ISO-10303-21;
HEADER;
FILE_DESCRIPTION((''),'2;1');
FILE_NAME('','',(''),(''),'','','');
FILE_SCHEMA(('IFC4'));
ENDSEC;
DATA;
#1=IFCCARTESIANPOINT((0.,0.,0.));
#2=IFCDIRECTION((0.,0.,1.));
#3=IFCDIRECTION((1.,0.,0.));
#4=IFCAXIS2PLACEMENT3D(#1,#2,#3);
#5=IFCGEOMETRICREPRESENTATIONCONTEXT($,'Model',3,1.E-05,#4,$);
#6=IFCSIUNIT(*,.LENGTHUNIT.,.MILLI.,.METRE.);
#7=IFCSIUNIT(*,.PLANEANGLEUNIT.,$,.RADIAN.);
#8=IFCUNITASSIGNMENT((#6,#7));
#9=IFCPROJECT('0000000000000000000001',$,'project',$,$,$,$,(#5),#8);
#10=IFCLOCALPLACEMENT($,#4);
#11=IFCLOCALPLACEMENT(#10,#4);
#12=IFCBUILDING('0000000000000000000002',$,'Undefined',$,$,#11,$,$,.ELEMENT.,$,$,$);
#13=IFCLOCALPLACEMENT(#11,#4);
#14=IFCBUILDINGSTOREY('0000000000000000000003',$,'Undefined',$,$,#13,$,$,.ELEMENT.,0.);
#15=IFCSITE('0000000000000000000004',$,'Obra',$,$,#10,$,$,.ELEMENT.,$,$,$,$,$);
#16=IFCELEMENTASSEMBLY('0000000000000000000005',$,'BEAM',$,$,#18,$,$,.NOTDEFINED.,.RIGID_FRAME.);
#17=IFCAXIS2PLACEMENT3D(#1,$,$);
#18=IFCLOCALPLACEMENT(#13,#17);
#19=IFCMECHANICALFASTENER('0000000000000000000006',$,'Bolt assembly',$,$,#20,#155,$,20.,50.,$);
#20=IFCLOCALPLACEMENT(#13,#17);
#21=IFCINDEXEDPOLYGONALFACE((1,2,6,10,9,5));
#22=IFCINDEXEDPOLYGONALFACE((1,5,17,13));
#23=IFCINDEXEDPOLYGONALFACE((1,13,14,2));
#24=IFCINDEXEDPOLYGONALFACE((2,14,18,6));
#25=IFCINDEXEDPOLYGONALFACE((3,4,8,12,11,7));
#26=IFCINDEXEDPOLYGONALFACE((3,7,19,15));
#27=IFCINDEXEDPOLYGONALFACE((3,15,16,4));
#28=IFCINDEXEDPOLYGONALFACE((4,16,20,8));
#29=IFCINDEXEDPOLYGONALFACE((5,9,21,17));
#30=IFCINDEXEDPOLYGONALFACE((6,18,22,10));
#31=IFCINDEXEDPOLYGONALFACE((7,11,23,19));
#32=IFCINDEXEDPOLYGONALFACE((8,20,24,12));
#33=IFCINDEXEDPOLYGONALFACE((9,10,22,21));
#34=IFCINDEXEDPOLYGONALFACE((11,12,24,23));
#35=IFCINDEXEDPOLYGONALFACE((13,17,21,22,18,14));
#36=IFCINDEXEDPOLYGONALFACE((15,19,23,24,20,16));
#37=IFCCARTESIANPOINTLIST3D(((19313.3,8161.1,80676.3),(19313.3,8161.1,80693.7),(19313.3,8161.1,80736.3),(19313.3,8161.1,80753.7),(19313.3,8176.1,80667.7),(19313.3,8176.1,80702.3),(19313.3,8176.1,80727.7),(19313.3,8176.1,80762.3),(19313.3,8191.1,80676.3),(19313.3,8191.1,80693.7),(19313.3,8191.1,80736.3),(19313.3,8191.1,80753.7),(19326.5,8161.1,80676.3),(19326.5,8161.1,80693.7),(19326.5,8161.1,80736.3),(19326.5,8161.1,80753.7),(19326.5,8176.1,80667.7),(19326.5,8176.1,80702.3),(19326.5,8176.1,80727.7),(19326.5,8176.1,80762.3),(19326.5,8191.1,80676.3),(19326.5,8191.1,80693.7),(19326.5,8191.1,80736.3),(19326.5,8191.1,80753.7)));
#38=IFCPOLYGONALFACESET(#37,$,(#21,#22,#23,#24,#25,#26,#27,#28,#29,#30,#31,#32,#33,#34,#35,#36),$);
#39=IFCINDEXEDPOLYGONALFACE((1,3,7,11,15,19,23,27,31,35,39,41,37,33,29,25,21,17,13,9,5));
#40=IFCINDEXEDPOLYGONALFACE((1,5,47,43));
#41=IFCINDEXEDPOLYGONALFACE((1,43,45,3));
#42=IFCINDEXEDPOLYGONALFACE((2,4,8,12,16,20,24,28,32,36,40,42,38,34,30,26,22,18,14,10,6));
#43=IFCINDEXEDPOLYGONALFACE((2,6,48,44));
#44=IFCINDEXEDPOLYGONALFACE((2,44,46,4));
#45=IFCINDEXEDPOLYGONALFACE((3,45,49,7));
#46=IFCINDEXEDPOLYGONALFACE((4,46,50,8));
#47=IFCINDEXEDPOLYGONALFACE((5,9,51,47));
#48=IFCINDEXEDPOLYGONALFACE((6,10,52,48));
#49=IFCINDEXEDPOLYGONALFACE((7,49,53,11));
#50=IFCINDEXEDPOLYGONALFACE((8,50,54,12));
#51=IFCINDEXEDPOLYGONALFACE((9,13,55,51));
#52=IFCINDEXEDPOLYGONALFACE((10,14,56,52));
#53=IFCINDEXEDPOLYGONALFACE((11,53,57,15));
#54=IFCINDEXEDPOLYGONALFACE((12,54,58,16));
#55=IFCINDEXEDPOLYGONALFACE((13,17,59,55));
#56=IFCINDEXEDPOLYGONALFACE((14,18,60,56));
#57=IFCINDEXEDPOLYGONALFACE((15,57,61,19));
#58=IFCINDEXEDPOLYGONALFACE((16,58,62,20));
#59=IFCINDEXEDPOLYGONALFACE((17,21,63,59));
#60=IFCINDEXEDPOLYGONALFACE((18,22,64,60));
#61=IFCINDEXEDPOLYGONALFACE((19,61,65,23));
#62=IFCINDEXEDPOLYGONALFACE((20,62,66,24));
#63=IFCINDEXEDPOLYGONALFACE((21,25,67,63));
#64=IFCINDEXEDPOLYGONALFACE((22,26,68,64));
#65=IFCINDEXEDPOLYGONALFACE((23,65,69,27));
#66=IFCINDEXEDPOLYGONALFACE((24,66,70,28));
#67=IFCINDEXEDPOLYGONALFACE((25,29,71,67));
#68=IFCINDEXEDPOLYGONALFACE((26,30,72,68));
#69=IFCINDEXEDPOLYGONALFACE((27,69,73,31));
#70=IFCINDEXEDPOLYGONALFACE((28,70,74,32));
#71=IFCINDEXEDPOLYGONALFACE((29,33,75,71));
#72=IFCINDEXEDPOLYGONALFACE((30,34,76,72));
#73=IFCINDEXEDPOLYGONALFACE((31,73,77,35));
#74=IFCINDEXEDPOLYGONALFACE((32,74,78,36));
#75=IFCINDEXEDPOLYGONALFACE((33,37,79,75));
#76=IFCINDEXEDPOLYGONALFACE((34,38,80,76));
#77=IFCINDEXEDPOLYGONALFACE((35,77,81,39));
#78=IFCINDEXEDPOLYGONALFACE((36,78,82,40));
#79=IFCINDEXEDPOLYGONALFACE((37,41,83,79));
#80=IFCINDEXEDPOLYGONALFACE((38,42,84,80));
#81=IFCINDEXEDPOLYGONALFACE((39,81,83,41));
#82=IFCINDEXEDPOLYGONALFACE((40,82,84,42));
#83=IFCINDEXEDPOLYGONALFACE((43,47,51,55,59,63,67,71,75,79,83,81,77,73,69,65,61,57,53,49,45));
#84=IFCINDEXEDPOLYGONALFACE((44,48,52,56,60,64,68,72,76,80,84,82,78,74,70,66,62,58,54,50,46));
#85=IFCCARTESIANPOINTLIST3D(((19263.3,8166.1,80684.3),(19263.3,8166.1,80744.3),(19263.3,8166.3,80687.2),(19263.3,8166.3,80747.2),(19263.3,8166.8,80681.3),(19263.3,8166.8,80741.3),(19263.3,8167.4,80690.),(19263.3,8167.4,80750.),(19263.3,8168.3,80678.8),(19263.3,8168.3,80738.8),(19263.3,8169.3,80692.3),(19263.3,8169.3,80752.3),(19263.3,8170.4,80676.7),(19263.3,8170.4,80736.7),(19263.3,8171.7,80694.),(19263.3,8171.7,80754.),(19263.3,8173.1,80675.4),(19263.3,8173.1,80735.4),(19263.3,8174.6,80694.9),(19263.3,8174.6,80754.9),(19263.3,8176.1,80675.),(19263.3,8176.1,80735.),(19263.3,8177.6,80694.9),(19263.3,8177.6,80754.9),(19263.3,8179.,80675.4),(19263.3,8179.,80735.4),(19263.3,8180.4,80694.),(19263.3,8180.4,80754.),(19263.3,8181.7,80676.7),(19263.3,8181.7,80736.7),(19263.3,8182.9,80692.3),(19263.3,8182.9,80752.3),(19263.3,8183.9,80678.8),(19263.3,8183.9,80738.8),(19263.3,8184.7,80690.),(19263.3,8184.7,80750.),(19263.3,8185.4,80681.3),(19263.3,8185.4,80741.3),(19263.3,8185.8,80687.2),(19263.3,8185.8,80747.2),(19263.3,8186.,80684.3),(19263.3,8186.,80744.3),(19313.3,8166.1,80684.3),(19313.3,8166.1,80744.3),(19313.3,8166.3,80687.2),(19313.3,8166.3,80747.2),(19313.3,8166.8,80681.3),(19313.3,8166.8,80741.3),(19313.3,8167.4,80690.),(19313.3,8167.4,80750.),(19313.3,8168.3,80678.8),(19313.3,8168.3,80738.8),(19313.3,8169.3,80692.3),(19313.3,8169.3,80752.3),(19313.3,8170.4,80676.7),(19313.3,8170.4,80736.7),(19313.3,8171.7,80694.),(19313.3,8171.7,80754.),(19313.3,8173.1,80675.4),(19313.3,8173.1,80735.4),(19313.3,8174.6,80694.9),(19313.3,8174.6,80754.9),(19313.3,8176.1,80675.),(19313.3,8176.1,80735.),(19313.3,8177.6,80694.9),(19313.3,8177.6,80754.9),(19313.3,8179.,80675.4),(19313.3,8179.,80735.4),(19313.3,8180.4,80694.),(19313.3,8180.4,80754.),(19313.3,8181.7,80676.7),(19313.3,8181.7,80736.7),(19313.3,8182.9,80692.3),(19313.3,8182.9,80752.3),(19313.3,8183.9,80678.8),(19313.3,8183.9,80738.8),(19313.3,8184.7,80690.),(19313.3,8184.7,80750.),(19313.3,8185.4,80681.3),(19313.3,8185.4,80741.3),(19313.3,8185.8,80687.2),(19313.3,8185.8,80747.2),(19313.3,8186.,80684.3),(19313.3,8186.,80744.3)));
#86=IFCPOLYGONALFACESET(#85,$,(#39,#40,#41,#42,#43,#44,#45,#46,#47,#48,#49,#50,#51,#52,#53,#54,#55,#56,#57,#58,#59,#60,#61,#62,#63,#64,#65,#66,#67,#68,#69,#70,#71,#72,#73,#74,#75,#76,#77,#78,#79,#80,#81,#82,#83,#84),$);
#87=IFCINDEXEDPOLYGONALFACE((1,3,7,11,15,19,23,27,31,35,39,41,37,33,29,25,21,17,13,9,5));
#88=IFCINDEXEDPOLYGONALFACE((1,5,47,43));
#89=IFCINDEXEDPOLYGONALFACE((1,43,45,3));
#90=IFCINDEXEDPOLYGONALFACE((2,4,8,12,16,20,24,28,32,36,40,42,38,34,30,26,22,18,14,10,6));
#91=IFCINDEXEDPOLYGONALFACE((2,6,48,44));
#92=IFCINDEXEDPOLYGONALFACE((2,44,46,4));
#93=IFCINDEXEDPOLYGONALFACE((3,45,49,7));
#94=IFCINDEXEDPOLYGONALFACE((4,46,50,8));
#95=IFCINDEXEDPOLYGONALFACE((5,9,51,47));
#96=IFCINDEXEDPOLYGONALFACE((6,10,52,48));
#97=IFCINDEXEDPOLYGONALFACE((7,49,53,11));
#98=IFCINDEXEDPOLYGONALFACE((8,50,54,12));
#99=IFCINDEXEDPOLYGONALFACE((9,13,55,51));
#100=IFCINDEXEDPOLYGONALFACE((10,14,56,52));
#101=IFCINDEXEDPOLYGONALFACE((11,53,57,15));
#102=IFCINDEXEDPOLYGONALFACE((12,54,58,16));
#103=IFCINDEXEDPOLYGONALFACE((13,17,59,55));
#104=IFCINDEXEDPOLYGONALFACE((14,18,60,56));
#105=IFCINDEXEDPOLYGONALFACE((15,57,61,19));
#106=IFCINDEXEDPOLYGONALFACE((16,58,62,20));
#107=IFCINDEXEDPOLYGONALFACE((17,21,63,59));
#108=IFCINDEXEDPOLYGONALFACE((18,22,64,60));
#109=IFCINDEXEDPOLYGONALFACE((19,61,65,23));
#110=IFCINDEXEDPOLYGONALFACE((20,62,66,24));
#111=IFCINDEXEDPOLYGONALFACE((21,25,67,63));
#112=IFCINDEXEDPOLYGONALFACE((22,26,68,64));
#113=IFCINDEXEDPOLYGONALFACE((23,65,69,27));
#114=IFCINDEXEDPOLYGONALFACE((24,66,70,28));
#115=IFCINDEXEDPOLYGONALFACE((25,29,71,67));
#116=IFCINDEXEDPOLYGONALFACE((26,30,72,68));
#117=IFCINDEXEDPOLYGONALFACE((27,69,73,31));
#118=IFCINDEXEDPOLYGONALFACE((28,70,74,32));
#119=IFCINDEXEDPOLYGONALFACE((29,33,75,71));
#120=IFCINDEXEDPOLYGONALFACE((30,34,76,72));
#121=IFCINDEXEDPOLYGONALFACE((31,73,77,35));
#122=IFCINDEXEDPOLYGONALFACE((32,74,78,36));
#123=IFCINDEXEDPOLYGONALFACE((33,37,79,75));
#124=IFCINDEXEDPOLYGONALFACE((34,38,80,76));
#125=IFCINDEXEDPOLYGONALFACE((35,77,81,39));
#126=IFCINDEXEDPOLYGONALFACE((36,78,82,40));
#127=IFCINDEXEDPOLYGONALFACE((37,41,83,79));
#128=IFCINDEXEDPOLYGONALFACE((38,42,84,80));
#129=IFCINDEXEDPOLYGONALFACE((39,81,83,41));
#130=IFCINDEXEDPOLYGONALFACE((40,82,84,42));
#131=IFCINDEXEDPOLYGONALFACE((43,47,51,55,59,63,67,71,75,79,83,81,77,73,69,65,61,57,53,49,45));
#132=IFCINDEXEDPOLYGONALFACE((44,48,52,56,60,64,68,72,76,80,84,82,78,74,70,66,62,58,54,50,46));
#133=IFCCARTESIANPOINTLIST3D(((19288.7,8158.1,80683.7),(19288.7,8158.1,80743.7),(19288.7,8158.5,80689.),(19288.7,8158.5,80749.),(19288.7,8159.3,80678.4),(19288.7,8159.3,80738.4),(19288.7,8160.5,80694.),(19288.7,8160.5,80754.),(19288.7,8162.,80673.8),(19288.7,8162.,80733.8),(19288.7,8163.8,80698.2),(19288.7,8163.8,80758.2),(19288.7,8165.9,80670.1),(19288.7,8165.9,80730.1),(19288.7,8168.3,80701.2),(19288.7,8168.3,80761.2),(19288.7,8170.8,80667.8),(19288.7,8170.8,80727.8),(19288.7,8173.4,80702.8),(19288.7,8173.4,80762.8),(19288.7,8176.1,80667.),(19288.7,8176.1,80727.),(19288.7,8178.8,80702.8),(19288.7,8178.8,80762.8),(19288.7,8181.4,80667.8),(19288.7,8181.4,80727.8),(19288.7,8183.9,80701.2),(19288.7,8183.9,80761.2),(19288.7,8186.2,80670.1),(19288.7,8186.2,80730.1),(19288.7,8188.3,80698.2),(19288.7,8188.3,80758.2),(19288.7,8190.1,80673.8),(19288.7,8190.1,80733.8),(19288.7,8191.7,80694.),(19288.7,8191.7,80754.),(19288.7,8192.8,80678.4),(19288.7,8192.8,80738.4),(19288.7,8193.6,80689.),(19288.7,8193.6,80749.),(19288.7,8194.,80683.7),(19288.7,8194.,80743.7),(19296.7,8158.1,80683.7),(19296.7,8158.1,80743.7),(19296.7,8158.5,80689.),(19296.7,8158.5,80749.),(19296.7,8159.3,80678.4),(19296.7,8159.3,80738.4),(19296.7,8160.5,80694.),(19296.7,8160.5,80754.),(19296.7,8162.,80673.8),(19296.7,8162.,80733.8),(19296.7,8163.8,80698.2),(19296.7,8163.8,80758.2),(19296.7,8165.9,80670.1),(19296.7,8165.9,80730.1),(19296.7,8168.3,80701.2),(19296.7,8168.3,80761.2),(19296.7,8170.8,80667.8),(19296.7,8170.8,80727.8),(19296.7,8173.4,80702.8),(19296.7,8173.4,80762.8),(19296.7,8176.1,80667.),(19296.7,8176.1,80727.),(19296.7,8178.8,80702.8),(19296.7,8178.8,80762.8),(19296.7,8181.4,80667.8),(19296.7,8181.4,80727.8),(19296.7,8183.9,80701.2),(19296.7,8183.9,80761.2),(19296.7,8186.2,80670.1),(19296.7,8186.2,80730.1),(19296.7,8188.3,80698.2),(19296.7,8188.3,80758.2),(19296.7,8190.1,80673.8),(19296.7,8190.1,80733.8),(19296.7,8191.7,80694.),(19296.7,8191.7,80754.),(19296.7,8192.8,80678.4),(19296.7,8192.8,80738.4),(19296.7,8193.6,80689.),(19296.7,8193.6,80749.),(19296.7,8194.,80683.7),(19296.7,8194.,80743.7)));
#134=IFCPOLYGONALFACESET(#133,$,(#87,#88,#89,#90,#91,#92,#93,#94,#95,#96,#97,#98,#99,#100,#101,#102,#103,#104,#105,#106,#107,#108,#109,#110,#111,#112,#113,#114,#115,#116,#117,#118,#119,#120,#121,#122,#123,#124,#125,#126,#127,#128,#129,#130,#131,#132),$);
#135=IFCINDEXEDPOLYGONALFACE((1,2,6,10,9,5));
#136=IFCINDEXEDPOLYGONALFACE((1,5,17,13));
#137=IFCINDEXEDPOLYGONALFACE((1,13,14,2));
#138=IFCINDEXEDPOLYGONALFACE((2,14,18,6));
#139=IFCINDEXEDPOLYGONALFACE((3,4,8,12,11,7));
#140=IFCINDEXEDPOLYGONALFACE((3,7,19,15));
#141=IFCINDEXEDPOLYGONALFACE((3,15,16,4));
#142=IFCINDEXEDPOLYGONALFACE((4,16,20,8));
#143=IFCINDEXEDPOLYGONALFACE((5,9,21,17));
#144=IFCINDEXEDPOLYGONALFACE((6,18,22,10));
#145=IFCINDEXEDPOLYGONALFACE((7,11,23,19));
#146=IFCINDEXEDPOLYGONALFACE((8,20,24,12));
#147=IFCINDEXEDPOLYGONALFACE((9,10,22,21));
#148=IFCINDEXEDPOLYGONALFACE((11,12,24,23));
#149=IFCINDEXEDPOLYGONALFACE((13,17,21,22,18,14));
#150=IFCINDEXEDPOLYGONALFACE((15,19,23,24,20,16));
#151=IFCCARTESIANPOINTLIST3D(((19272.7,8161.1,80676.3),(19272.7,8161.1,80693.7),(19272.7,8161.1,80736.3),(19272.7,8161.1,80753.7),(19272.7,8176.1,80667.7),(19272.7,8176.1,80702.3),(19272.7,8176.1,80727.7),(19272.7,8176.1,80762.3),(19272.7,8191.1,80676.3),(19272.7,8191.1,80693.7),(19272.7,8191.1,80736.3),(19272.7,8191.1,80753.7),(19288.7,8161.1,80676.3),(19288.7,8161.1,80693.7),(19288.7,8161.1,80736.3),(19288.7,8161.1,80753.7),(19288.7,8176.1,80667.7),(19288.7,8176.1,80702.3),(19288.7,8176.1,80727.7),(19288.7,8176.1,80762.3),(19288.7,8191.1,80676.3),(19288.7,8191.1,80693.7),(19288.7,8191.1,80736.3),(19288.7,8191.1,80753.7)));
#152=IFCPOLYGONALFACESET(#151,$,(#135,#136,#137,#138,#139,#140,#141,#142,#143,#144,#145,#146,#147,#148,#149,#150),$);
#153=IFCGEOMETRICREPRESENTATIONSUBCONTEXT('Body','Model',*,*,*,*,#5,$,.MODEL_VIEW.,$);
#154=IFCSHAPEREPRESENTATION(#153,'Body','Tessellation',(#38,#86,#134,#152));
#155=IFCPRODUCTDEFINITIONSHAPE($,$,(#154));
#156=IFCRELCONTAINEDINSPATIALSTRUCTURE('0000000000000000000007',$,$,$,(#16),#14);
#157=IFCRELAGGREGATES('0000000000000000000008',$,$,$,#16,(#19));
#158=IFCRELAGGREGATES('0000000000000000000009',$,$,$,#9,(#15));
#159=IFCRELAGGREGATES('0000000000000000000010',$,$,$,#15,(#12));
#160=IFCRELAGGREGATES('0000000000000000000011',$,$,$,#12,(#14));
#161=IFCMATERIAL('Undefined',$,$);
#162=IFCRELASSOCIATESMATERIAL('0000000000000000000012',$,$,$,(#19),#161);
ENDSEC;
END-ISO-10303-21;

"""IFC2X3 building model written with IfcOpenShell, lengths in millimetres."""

from ifc_helpers import new_model, si_unit, frame, origin_with_axes, origin_2d_with_axis, place, context, subcontext, project, spatial, polyline, circle, outline, extrude, source, transform, mapped, material, element, aggregate, save


model = new_model("IFC2X3")

# Units and contexts
model_context = context("Model", 3, precision=1e-05, world=origin_with_axes())
body_context = subcontext(model_context, "Body", "Model", "MODEL_VIEW")
ifc_project = project(units=[si_unit("LENGTHUNIT", "METRE", prefix="MILLI"), si_unit("PLANEANGLEUNIT", "RADIAN")], contexts=[model_context])

# Site, building, storey
site_placement = place(None, origin_with_axes())
site = spatial("IfcSite", under=ifc_project, at=site_placement, Name="Obra", CompositionType="ELEMENT")
building_placement = place(site_placement, origin_with_axes())
building = spatial("IfcBuilding", under=site, at=building_placement, Name="Undefined", CompositionType="ELEMENT")
storey_placement = place(building_placement, origin_with_axes())
storey = spatial("IfcBuildingStorey", under=building, at=storey_placement, Name="Undefined", CompositionType="ELEMENT", Elevation=0.0)

# Shared definitions
ifc_material_1 = material(Name="Undefined")
shared_shape_1 = source(origin_with_axes(), body_context, "Body", "SweptSolid", [
    extrude(outline(polyline([(17.3, 0.0), (8.7, 15.0), (-8.7, 15.0), (-17.3, 0.0), (-8.7, -15.0), (8.7, -15.0), (17.3, 0.0)])), frame((0.0, -26.5, 0.0), z_axis=(0.0, 1.0, 0.0), x_axis=(1.0, 0.0, 0.0)), (0.0, 0.0, 1.0), 13.2),
    extrude(circle(Radius=10.0, at=origin_2d_with_axis()), frame((0.0, -13.3, 0.0), z_axis=(0.0, 1.0, 0.0), x_axis=(1.0, 0.0, 0.0)), (0.0, 0.0, 1.0), 50.0),
    extrude(circle(Radius=18.0, at=origin_2d_with_axis()), frame((0.0, 3.3, 0.0), z_axis=(0.0, 1.0, 0.0), x_axis=(1.0, 0.0, 0.0)), (0.0, 0.0, 1.0), 8.0),
    extrude(outline(polyline([(17.3, 0.0), (8.7, 15.0), (-8.7, 15.0), (-17.3, 0.0), (-8.7, -15.0), (8.7, -15.0), (17.3, 0.0)])), frame((0.0, 11.3, 0.0), z_axis=(0.0, 1.0, 0.0), x_axis=(1.0, 0.0, 0.0)), (0.0, 0.0, 1.0), 16.0),
])

# Element assembly, mechanical fastener
assembly_1_placement = place(storey_placement, origin_with_axes())
assembly_1 = element("IfcElementAssembly", 1, at=assembly_1_placement, inside=storey, Name="BEAM", AssemblyPlace="NOTDEFINED", PredefinedType="RIGID_FRAME")
mechanical_fastener_1_placement = place(assembly_1_placement, frame((19300.0, 8136.1, 80850.0), z_axis=(0.0, 1.0, 0.0), x_axis=(0.0, 0.0, -1.0)))
mechanical_fastener_1 = element("IfcMechanicalFastener", 2, at=mechanical_fastener_1_placement, material=ifc_material_1, Name="Bolt assembly", NominalDiameter=20.0, NominalLength=50.0, context=body_context, shape_type="MappedRepresentation", body=[
    mapped(shared_shape_1, transform((105.0, 0.0, 40.0))),
    mapped(shared_shape_1, transform((165.0, 0.0, 40.0))),
])
aggregate(assembly_1, [mechanical_fastener_1])

save(model, "model.ifc")
